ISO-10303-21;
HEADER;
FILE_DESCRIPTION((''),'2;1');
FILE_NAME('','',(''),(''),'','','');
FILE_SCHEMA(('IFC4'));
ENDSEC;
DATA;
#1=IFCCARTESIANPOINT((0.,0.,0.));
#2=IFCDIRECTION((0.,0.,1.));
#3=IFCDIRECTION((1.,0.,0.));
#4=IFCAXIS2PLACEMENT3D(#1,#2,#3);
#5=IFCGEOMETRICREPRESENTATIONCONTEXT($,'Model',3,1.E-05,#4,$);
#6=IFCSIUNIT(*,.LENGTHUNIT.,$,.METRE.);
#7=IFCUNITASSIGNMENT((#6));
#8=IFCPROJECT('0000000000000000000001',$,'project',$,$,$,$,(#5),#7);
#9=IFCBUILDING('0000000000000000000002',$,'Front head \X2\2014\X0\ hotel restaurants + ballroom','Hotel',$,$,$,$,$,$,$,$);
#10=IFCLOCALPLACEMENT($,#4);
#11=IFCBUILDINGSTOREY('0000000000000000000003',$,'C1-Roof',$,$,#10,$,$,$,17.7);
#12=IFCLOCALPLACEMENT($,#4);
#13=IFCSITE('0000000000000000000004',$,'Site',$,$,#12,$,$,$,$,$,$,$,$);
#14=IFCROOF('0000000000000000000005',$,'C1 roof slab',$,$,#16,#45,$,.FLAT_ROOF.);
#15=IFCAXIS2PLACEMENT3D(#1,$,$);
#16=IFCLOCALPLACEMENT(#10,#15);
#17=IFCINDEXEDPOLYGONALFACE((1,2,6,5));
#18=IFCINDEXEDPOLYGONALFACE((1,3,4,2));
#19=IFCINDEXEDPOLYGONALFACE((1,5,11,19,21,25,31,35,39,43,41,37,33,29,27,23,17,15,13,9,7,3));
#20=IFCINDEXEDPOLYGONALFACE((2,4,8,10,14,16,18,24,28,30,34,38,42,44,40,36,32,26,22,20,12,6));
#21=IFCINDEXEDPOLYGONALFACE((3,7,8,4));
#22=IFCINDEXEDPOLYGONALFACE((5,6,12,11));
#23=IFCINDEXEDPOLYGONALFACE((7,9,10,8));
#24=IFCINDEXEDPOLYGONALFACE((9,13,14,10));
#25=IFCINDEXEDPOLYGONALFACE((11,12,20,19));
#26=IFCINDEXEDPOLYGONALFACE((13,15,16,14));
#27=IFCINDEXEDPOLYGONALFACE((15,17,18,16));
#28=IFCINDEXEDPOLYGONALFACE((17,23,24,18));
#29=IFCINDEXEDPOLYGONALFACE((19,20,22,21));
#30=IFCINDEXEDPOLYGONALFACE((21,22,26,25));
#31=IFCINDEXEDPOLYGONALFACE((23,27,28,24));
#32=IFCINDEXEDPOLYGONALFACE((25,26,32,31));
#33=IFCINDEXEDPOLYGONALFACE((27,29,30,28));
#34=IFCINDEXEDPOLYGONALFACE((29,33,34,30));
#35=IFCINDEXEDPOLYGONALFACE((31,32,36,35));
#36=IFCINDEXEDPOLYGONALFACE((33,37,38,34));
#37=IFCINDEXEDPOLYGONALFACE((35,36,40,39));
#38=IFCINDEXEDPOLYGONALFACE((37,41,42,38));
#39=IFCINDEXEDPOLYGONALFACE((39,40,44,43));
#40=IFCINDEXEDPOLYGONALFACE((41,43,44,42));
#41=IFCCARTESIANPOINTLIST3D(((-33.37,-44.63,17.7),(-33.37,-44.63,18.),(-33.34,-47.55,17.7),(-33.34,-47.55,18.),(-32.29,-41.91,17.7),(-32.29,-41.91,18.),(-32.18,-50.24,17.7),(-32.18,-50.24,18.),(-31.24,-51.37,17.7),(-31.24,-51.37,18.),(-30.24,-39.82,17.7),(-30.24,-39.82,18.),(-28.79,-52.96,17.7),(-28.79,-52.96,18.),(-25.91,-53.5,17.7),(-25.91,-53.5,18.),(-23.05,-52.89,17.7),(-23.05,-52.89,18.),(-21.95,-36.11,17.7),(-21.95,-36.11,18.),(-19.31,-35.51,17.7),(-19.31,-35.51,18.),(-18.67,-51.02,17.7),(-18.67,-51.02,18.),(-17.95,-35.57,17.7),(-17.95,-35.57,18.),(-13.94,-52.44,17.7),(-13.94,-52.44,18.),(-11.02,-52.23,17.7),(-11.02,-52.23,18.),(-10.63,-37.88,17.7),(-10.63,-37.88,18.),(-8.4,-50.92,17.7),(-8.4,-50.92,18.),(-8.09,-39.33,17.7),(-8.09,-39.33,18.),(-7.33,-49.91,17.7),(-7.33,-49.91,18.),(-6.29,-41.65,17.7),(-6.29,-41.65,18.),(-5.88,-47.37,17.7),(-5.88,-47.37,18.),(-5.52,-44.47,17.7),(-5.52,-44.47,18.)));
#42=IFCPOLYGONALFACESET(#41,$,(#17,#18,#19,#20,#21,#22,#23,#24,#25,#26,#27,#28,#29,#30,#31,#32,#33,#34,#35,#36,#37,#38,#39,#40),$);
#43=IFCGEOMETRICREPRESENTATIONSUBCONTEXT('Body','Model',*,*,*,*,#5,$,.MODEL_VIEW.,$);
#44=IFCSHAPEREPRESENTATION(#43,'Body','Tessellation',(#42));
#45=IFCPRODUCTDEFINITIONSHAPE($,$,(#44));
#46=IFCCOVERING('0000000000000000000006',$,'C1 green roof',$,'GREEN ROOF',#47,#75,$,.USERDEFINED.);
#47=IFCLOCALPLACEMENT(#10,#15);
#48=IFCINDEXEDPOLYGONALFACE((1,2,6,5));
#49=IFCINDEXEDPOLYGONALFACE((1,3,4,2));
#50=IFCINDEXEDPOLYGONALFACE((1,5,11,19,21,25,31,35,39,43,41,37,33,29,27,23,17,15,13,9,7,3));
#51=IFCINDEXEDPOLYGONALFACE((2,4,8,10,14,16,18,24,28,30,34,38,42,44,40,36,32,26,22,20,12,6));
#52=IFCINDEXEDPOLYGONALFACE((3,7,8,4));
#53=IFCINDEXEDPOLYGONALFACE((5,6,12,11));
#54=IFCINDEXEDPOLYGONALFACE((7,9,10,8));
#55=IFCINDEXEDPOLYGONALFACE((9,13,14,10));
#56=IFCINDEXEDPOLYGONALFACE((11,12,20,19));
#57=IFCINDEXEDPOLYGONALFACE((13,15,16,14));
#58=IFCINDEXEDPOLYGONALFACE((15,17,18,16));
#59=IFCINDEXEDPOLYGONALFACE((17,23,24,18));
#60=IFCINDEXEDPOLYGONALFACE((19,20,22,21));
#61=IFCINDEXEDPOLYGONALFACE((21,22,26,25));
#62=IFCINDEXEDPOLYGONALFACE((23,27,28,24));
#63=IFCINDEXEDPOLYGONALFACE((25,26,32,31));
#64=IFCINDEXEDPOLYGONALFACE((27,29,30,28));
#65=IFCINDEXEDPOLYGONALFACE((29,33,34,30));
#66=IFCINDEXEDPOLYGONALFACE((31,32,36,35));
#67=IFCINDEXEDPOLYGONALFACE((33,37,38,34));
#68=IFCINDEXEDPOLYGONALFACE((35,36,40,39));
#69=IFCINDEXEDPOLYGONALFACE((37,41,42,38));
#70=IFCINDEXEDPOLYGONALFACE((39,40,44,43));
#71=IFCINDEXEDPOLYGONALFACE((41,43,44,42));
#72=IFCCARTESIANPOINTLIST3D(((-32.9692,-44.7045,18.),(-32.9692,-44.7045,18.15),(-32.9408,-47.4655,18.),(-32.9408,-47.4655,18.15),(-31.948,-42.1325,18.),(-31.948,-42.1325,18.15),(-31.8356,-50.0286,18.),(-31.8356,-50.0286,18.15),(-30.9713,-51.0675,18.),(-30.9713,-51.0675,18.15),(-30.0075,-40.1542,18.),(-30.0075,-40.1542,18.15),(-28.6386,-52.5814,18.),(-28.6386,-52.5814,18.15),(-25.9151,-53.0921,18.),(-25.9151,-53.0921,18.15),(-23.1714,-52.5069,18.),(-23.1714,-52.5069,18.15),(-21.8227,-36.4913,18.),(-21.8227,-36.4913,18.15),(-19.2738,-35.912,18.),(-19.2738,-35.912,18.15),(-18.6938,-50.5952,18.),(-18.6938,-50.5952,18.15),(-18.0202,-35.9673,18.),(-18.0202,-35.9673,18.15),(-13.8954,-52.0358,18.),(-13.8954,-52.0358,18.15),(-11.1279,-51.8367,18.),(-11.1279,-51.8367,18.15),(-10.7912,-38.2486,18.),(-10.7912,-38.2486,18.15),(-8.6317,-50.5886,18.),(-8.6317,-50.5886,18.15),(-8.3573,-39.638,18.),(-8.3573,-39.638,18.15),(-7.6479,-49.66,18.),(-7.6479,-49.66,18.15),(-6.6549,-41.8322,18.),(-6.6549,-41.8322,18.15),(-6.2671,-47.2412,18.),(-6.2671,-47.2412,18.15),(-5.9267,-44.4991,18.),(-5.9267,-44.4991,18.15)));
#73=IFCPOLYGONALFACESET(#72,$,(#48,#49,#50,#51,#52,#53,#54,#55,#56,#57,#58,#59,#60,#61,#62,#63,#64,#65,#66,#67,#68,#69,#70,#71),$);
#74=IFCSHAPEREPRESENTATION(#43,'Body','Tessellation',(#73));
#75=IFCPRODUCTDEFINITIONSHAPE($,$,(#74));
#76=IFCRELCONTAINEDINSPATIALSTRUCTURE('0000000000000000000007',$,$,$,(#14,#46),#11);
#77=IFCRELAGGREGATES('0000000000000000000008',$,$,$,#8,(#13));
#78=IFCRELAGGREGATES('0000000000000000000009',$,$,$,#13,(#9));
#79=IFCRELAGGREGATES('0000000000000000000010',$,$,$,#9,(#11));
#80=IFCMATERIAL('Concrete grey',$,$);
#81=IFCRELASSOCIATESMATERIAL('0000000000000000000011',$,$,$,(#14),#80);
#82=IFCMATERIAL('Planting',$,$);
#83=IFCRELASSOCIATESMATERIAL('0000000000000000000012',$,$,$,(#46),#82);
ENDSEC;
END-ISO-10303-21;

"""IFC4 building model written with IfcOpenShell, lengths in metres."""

from ifc_helpers import new_model, si_unit, frame, origin_with_axes, place, context, subcontext, project, spatial, polyline, outline, extrude, material, element, save


model = new_model("IFC4")

# Units and contexts
model_context = context("Model", 3, precision=1e-05, world=origin_with_axes())
body_context = subcontext(model_context, "Body", "Model", "MODEL_VIEW")
ifc_project = project(units=[si_unit("LENGTHUNIT", "METRE")], contexts=[model_context])

# Site, building, storey
site_placement = place(None, origin_with_axes())
site = spatial("IfcSite", under=ifc_project, at=site_placement, Name="Site")
building = spatial("IfcBuilding", under=site, Name="Front head — hotel restaurants + ballroom", Description="Hotel")
storey_placement = place(None, origin_with_axes())
storey = spatial("IfcBuildingStorey", under=building, at=storey_placement, Name="C1-Roof", Elevation=17.7)

# Roof
ifc_material_1 = material(Name="Concrete grey")
roof_placement = place(storey_placement, origin_with_axes())
element("IfcRoof", 1, at=roof_placement, inside=storey, material=ifc_material_1, Name="C1 roof slab", PredefinedType="FLAT_ROOF", context=body_context, shape_type="SweptSolid", body=[
    extrude(outline(polyline([(-21.95, -36.11), (-30.24, -39.82), (-32.29, -41.91), (-33.37, -44.63), (-33.34, -47.55), (-32.18, -50.24), (-31.24, -51.37), (-28.79, -52.96), (-25.91, -53.5), (-23.05, -52.89), (-18.67, -51.02), (-13.94, -52.44), (-11.02, -52.23), (-8.4, -50.92), (-7.33, -49.91), (-5.88, -47.37), (-5.52, -44.47), (-6.29, -41.65), (-8.09, -39.33), (-10.63, -37.88), (-17.95, -35.57), (-19.31, -35.51), (-21.95, -36.11)])), frame((0.0, 0.0, 17.7), z_axis=(0.0, 0.0, 1.0), x_axis=(1.0, 0.0, 0.0)), (0.0, 0.0, 1.0), 0.3),
])

# Covering
ifc_material_2 = material(Name="Planting")
covering_placement = place(storey_placement, origin_with_axes())
element("IfcCovering", 2, at=covering_placement, inside=storey, material=ifc_material_2, Name="C1 green roof", ObjectType="GREEN ROOF", PredefinedType="USERDEFINED", context=body_context, shape_type="SweptSolid", body=[
    extrude(outline(polyline([(-21.8227, -36.4913), (-30.0075, -40.1542), (-31.948, -42.1325), (-32.9692, -44.7045), (-32.9408, -47.4655), (-31.8356, -50.0286), (-30.9713, -51.0675), (-28.6386, -52.5814), (-25.9151, -53.0921), (-23.1714, -52.5069), (-18.6938, -50.5952), (-13.8954, -52.0358), (-11.1279, -51.8367), (-8.6317, -50.5886), (-7.6479, -49.66), (-6.2671, -47.2412), (-5.9267, -44.4991), (-6.6549, -41.8322), (-8.3573, -39.638), (-10.7912, -38.2486), (-18.0202, -35.9673), (-19.2738, -35.912), (-21.8227, -36.4913)])), frame((0.0, 0.0, 18.0), z_axis=(0.0, 0.0, 1.0), x_axis=(1.0, 0.0, 0.0)), (0.0, 0.0, 1.0), 0.15),
])

save(model, "model.ifc")
